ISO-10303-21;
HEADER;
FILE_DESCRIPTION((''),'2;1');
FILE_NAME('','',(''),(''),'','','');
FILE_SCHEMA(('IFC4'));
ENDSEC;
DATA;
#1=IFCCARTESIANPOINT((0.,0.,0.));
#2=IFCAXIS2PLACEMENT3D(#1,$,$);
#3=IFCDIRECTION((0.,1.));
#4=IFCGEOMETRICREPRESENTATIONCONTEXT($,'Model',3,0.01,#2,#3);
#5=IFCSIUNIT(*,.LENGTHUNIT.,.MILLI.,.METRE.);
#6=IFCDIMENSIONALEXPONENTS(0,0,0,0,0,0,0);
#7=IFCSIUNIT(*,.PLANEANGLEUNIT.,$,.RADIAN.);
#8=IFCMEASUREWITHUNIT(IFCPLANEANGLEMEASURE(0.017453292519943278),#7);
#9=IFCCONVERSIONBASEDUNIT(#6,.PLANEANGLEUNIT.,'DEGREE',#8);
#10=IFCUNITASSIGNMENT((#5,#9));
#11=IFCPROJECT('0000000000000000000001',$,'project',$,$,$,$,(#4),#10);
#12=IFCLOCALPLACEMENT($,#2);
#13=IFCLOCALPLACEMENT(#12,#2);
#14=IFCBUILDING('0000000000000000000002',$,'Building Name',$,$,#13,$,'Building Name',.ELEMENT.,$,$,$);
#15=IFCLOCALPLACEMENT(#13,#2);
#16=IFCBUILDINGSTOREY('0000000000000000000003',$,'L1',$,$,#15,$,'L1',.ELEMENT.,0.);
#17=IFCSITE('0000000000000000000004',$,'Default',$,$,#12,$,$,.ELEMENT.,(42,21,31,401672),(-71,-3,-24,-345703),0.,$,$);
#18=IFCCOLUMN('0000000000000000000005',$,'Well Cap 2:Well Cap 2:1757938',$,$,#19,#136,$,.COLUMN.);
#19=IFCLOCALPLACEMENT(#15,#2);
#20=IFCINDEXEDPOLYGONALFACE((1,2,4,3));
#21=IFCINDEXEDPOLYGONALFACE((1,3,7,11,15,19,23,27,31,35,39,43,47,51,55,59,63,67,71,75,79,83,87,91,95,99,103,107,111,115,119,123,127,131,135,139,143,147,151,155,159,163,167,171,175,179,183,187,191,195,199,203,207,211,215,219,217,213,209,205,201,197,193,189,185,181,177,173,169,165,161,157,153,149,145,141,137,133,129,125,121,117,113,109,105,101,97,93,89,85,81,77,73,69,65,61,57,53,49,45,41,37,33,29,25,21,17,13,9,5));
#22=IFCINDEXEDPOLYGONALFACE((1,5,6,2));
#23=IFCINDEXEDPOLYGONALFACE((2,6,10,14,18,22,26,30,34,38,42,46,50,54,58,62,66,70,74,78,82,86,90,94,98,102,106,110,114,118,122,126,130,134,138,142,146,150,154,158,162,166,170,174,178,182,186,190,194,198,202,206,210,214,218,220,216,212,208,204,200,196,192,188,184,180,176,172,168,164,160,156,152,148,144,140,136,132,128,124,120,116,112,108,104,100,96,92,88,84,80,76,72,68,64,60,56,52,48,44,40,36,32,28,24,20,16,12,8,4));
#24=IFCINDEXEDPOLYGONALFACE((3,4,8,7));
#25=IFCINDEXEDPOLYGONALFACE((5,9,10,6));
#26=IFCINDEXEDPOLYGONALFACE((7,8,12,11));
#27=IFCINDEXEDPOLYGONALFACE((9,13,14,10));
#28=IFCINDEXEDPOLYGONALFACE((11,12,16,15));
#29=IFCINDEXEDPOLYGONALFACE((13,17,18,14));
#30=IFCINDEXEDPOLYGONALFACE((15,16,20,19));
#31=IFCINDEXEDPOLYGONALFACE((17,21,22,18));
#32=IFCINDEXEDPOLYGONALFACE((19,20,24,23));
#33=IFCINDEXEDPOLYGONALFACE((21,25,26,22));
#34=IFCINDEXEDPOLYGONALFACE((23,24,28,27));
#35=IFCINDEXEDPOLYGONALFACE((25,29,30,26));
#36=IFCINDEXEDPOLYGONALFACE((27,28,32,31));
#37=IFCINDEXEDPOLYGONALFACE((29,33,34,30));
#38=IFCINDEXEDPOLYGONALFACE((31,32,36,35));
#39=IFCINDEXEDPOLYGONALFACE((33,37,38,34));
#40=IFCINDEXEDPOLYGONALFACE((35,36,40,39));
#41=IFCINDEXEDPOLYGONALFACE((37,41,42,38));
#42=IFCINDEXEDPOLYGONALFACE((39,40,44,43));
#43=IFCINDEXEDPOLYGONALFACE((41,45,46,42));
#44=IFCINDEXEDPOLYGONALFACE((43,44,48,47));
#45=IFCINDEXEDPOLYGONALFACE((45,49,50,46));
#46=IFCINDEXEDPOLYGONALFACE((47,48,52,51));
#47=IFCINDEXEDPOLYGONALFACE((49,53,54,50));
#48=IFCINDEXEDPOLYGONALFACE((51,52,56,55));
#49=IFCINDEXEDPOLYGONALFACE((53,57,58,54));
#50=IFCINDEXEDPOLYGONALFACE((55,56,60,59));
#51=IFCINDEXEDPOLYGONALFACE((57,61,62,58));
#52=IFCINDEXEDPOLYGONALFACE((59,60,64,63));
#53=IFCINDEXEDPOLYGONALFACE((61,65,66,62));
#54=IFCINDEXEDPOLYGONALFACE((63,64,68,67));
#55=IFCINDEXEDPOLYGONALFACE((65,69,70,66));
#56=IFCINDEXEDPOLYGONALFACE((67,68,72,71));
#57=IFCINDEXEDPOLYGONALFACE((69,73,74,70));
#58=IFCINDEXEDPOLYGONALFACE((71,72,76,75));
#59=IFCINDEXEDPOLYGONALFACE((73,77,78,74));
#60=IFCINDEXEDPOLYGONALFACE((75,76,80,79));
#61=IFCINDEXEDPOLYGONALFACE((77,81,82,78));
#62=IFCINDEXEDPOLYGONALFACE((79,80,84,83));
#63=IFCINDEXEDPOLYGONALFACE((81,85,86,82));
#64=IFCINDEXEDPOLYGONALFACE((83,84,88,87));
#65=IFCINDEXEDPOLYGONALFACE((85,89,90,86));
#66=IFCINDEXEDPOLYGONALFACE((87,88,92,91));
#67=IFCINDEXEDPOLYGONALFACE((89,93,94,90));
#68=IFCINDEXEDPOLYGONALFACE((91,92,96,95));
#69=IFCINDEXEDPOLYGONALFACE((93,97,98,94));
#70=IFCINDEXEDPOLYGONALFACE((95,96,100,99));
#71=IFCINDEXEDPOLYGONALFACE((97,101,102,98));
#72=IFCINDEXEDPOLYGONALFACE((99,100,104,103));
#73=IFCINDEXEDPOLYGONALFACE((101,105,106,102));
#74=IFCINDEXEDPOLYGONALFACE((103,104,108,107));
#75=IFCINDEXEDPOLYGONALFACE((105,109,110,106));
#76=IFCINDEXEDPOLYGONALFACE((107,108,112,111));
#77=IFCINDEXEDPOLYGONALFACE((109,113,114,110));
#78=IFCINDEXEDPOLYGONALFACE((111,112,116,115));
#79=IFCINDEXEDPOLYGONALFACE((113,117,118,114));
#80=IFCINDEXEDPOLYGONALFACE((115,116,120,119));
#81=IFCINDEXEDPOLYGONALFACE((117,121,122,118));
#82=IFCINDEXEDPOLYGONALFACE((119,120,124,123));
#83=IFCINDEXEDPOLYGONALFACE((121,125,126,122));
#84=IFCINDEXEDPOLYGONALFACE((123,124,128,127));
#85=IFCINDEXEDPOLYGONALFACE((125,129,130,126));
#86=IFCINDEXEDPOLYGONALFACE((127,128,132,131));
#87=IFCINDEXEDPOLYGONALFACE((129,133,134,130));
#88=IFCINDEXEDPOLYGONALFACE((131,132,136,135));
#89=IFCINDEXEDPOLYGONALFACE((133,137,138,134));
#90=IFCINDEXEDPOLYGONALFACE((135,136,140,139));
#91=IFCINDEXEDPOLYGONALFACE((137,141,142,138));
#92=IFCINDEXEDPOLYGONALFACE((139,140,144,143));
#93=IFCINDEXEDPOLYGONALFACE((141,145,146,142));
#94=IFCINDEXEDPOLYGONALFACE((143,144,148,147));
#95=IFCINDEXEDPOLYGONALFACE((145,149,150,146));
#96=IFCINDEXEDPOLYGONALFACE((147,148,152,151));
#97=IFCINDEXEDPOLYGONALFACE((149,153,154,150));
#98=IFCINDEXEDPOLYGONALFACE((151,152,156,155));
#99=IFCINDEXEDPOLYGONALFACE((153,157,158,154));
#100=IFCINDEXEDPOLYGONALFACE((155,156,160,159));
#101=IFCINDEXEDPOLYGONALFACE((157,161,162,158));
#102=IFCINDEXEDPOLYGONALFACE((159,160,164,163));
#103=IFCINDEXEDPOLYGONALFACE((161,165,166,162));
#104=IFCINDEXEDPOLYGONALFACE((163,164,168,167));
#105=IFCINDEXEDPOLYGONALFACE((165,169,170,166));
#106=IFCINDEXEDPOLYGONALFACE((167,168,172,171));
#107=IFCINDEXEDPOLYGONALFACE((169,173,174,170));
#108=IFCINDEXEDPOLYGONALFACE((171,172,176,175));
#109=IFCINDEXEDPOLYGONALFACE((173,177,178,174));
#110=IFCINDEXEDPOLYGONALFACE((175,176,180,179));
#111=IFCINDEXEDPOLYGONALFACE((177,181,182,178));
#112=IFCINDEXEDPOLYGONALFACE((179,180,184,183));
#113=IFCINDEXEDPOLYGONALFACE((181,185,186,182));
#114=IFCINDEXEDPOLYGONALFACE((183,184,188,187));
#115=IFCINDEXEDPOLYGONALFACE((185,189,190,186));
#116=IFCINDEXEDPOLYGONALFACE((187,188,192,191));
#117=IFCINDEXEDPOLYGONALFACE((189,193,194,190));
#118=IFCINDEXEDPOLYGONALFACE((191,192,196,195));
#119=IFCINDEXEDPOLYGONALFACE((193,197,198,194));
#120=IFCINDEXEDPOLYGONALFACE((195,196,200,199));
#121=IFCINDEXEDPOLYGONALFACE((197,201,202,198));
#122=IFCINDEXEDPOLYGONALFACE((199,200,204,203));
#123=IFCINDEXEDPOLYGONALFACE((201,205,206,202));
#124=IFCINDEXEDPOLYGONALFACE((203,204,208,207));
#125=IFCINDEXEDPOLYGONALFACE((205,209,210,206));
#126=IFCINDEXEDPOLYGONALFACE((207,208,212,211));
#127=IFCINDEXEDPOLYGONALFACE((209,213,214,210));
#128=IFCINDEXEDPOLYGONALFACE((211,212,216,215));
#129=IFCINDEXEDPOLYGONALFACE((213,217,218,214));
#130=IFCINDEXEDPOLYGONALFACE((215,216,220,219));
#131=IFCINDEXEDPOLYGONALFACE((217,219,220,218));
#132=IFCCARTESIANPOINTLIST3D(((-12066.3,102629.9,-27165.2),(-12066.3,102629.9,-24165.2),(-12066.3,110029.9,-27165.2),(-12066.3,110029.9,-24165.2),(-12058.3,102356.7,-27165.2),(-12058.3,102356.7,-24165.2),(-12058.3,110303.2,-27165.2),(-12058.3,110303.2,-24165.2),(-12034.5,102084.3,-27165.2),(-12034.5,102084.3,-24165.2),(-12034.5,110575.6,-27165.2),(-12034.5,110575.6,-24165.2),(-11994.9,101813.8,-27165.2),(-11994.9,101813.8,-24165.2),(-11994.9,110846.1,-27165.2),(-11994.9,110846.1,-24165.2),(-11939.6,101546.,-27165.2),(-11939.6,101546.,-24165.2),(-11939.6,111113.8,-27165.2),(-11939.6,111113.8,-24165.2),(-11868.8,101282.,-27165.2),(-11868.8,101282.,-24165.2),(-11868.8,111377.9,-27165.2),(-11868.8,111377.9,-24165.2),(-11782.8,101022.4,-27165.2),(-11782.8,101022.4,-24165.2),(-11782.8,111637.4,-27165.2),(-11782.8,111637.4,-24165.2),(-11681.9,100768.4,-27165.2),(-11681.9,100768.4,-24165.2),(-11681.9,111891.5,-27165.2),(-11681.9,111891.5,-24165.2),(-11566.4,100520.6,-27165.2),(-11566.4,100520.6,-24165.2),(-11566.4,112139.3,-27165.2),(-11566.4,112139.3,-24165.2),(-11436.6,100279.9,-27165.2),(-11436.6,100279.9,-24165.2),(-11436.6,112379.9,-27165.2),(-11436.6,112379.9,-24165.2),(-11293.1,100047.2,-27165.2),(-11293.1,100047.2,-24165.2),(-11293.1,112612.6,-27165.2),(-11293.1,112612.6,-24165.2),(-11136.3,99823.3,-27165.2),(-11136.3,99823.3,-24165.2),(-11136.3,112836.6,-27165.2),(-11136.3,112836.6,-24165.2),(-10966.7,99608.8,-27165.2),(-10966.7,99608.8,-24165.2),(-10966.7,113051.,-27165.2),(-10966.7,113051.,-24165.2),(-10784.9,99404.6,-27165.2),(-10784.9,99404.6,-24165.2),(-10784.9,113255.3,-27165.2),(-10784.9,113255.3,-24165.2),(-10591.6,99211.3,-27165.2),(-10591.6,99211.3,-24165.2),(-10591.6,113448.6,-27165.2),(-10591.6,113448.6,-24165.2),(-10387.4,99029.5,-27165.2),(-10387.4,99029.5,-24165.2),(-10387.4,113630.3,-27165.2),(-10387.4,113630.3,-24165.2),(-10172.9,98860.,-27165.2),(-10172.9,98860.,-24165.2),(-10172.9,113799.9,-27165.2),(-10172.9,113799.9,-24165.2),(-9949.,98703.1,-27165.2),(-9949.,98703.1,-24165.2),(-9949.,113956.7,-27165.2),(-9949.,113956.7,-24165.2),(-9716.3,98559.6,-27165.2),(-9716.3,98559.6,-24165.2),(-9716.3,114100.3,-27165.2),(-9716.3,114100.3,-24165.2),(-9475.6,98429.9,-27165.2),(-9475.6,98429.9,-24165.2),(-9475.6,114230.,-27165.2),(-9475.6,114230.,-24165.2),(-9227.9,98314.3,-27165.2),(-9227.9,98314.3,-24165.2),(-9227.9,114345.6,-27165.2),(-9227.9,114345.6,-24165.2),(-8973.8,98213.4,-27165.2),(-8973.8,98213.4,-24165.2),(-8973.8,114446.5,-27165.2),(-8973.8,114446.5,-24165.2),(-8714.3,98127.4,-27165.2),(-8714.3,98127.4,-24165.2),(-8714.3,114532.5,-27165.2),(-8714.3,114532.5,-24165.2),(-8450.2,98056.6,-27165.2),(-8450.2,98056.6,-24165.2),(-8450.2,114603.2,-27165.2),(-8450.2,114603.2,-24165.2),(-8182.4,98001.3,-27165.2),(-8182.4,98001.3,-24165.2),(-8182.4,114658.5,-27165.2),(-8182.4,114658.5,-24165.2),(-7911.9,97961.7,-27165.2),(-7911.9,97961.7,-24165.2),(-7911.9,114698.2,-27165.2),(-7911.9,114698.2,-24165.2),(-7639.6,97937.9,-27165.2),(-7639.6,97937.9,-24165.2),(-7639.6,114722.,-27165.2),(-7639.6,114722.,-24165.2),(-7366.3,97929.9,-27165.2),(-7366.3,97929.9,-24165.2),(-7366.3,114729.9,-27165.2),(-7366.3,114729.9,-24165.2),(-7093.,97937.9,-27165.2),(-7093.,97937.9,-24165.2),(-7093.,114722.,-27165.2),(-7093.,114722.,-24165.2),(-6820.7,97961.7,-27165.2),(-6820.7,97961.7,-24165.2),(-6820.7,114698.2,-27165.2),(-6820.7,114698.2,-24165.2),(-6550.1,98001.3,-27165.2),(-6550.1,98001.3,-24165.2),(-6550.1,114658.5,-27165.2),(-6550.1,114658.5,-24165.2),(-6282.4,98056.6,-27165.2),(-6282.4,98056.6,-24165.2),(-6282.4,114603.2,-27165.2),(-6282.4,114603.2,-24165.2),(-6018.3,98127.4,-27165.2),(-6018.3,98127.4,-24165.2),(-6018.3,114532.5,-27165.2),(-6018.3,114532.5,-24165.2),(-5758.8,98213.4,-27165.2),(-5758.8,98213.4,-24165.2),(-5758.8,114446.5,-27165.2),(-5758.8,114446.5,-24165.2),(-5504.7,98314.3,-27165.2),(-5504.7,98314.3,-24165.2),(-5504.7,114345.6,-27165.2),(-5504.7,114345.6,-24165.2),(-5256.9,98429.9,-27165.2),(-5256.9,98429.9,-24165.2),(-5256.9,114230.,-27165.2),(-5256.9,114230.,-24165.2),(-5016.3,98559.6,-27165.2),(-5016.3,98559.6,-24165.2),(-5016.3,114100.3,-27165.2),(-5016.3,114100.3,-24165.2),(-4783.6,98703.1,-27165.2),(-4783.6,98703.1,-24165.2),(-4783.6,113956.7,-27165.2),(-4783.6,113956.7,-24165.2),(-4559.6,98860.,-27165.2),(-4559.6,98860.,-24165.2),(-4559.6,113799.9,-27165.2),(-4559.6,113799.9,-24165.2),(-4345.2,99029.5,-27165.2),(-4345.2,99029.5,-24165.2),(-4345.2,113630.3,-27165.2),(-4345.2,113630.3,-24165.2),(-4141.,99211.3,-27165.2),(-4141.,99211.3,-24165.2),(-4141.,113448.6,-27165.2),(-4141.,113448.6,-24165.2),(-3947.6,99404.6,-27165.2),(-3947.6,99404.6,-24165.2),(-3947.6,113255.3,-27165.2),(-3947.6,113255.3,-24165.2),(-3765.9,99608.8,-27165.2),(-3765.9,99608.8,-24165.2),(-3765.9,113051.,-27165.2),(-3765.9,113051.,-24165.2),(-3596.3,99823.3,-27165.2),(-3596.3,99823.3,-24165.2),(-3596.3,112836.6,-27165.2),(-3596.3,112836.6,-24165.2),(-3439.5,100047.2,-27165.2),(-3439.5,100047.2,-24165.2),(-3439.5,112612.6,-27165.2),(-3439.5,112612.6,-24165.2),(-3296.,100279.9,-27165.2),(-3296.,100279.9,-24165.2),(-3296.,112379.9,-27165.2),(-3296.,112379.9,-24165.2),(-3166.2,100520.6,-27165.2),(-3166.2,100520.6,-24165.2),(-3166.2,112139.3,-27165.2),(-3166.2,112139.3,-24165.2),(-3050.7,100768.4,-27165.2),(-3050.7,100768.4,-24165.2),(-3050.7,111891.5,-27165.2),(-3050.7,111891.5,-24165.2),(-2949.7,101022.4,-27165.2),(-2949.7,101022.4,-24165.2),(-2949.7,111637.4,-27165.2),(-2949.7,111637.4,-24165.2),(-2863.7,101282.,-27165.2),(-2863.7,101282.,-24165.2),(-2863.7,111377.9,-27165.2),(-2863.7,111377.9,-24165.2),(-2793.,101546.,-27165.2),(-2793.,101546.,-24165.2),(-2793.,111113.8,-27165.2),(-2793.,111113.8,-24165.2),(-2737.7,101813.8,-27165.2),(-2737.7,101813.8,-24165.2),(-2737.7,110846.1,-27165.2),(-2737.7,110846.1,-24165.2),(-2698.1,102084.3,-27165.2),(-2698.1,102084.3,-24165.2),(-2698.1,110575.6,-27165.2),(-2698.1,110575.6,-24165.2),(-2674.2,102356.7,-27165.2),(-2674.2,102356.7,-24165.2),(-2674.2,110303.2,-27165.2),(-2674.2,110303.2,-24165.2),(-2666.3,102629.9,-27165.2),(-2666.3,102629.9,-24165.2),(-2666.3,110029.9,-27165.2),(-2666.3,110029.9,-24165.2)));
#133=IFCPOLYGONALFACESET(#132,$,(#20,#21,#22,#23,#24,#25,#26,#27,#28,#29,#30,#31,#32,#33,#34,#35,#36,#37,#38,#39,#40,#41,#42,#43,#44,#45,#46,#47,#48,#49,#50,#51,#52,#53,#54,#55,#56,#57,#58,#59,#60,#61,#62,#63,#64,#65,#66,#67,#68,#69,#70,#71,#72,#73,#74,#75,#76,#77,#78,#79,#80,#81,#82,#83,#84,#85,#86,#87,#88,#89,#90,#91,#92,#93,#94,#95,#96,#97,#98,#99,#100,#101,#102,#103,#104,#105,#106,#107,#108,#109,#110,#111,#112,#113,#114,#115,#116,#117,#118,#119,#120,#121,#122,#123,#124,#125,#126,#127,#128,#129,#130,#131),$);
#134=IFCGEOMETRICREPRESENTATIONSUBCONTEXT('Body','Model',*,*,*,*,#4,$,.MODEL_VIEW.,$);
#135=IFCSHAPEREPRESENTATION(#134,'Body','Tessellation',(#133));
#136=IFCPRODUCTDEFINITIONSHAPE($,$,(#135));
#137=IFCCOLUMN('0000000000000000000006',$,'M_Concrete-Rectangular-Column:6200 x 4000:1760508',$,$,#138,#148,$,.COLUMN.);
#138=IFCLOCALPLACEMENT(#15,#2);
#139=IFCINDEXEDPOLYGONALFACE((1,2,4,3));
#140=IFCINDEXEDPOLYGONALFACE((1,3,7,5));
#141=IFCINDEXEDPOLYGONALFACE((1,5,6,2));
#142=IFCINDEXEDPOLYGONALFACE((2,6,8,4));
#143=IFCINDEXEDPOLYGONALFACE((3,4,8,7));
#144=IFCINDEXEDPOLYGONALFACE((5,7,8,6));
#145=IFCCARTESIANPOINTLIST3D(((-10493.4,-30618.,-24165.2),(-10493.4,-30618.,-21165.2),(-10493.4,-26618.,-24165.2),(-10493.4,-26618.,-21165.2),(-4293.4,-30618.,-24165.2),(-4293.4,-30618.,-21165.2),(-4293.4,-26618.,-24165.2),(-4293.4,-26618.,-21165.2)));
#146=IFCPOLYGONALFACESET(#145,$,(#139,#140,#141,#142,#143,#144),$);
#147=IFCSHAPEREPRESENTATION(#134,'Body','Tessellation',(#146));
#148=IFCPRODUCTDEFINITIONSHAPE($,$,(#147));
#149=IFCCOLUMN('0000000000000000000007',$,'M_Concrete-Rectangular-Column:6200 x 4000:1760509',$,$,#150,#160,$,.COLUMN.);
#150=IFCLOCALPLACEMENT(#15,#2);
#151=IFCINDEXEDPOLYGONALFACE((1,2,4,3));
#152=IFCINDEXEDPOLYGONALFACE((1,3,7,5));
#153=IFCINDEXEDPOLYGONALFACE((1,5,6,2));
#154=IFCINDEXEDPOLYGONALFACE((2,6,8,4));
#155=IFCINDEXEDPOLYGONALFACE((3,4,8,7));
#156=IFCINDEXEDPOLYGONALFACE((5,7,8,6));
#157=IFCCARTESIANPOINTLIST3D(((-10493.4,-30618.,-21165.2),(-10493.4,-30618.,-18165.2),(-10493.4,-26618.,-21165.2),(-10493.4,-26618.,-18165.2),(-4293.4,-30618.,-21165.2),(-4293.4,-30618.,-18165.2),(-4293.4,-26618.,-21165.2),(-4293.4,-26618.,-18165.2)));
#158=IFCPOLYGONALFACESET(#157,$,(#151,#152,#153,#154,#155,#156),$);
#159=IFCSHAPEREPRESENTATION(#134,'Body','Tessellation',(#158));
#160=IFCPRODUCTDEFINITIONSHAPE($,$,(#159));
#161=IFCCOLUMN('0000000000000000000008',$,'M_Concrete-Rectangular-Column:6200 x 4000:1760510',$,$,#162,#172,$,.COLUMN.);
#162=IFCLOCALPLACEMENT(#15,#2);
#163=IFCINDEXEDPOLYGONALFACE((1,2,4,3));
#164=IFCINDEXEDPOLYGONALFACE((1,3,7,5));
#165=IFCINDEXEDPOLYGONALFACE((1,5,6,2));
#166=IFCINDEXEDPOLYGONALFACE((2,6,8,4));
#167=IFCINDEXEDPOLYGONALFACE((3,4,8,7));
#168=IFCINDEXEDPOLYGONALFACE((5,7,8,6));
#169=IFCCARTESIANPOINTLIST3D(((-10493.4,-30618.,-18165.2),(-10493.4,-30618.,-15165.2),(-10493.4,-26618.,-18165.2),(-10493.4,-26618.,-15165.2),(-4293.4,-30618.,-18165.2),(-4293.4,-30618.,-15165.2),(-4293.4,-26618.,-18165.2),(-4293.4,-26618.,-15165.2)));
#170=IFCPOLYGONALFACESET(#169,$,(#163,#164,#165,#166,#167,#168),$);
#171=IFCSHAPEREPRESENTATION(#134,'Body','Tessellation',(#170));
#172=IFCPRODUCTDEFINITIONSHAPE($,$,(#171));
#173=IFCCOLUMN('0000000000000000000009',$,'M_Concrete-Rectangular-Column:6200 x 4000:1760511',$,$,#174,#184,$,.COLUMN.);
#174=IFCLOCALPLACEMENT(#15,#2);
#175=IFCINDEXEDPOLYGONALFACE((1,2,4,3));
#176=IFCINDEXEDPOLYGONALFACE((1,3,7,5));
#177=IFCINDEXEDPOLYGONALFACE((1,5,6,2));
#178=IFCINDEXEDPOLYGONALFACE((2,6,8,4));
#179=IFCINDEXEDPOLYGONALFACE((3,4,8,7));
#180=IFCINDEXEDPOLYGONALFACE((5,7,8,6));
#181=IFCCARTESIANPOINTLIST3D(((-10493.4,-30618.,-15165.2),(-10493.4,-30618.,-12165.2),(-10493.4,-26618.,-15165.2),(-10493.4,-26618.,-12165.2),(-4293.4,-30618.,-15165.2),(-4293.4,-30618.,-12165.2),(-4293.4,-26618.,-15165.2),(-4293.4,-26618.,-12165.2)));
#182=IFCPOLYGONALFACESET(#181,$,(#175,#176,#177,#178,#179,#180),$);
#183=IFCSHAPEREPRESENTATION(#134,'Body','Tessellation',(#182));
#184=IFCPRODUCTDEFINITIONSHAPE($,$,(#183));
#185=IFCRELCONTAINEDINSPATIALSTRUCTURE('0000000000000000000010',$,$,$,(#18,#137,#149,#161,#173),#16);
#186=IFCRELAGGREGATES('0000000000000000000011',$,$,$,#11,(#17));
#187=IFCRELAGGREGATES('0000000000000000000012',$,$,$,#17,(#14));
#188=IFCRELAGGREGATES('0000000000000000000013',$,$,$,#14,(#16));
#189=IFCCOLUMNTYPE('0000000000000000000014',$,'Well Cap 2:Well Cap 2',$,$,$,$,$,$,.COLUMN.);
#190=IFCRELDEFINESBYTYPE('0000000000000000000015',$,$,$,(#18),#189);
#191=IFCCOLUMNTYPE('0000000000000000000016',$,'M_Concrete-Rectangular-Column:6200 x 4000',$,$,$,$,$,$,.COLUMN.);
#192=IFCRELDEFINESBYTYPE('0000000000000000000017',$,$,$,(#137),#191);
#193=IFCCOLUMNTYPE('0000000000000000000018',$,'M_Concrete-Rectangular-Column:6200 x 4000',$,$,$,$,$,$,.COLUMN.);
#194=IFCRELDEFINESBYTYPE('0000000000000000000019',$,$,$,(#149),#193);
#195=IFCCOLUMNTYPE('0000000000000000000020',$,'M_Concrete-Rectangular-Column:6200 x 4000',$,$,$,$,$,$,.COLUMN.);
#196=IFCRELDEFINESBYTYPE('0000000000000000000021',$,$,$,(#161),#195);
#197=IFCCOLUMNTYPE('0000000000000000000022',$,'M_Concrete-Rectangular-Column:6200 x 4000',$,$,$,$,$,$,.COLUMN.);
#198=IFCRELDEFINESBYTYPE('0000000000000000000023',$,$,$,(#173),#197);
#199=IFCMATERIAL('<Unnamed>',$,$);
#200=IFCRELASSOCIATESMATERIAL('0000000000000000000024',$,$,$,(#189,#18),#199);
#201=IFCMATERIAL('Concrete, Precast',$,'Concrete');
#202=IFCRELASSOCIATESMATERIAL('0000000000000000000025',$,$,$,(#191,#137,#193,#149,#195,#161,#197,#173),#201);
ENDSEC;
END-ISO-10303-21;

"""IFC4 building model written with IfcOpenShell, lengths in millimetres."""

from ifc_helpers import new_model, entity, si_unit, converted_unit, direction, frame, origin, place, context, subcontext, project, spatial, line, arc, indexed_curve, outline, extrude, source, transform, mapped, material, type_object, type_shapes, element, save


model = new_model("IFC4")

# Units and contexts
model_context = context("Model", 3, precision=0.01, world=origin(), true_north=direction((0.0, 1.0)))
body_context = subcontext(model_context, "Body", "Model", "MODEL_VIEW")
ifc_project = project(units=[si_unit("LENGTHUNIT", "METRE", prefix="MILLI"), converted_unit("PLANEANGLEUNIT", "DEGREE", entity("IfcPlaneAngleMeasure", 0.017453292519943278), si_unit("PLANEANGLEUNIT", "RADIAN"), dimensions=[0, 0, 0, 0, 0, 0, 0])], contexts=[model_context])

# Site, building, storey
site_placement = place(None, origin())
site = spatial("IfcSite", under=ifc_project, at=site_placement, Name="Default", CompositionType="ELEMENT", RefLatitude=(42, 21, 31, 401672), RefLongitude=(-71, -3, -24, -345703), RefElevation=0.0)
building_placement = place(site_placement, origin())
building = spatial("IfcBuilding", under=site, at=building_placement, Name="Building Name", LongName="Building Name", CompositionType="ELEMENT")
storey_placement = place(building_placement, origin())
storey = spatial("IfcBuildingStorey", under=building, at=storey_placement, Name="L1", LongName="L1", CompositionType="ELEMENT", Elevation=0.0)

# Columns
ifc_material_1 = material(Name="<Unnamed>")
column_type_1 = type_object("IfcColumnType", Name="Well Cap 2:Well Cap 2", PredefinedType="COLUMN", material=ifc_material_1)
shared_shape_1 = source(origin(), body_context, "Body", "SweptSolid", [
    extrude(outline(indexed_curve([(-3700.0, -4700.0), (3700.0, -4700.0), (8400.0, 0.0), (3700.0, 4700.0), (-3700.0, 4700.0), (-8400.0, 0.0)], segments=[line(1, 2), arc(2, 3, 4), line(4, 5), arc(5, 6, 1)], self_intersect=False)), frame((8064.3, 0.0, 0.0), z_axis=(0.0, 0.0, 1.0), x_axis=(0.0, -1.0, 0.0)), (0.0, 0.0, 1.0), 3000.0),
])
type_shapes(column_type_1, [shared_shape_1])
column_1_placement = place(storey_placement, frame((-15430.5, 106329.9, -27165.2)))
element("IfcColumn", 1, at=column_1_placement, inside=storey, type_object=column_type_1, material=ifc_material_1, Name="Well Cap 2:Well Cap 2:1757938", PredefinedType="COLUMN", context=body_context, shape_type="MappedRepresentation", body=[
    mapped(shared_shape_1, transform((0.0, 0.0, 0.0), scale=1.0)),
])
ifc_material_2 = material(Name="Concrete, Precast", Category="Concrete")
column_type_2 = type_object("IfcColumnType", Name="M_Concrete-Rectangular-Column:6200 x 4000", PredefinedType="COLUMN", material=ifc_material_2)
shared_shape_2 = source(origin(), body_context, "Body", "SweptSolid", [
    extrude(outline(indexed_curve([(-2000.0, -3100.0), (2000.0, -3100.0), (2000.0, 3100.0), (-2000.0, 3100.0), (-2000.0, -3100.0)], self_intersect=False)), frame((-7393.4, -28618.0, -24165.2), z_axis=(0.0, 0.0, 1.0), x_axis=(0.0, -1.0, 0.0)), (0.0, 0.0, 1.0), 3000.0),
])
type_shapes(column_type_2, [shared_shape_2])
column_2_placement = place(storey_placement, origin())
element("IfcColumn", 2, at=column_2_placement, inside=storey, type_object=column_type_2, material=ifc_material_2, Name="M_Concrete-Rectangular-Column:6200 x 4000:1760508", PredefinedType="COLUMN", context=body_context, shape_type="MappedRepresentation", body=[
    mapped(shared_shape_2, transform((0.0, 0.0, 0.0), scale=1.0)),
])
column_type_3 = type_object("IfcColumnType", Name="M_Concrete-Rectangular-Column:6200 x 4000", PredefinedType="COLUMN", material=ifc_material_2)
shared_shape_3 = source(origin(), body_context, "Body", "SweptSolid", [
    extrude(outline(indexed_curve([(-2000.0, -3100.0), (2000.0, -3100.0), (2000.0, 3100.0), (-2000.0, 3100.0), (-2000.0, -3100.0)], self_intersect=False)), frame((-7393.4, -28618.0, -21165.2), z_axis=(0.0, 0.0, 1.0), x_axis=(0.0, -1.0, 0.0)), (0.0, 0.0, 1.0), 3000.0),
])
type_shapes(column_type_3, [shared_shape_3])
column_3_placement = place(storey_placement, origin())
element("IfcColumn", 3, at=column_3_placement, inside=storey, type_object=column_type_3, material=ifc_material_2, Name="M_Concrete-Rectangular-Column:6200 x 4000:1760509", PredefinedType="COLUMN", context=body_context, shape_type="MappedRepresentation", body=[
    mapped(shared_shape_3, transform((0.0, 0.0, 0.0), scale=1.0)),
])
column_type_4 = type_object("IfcColumnType", Name="M_Concrete-Rectangular-Column:6200 x 4000", PredefinedType="COLUMN", material=ifc_material_2)
shared_shape_4 = source(origin(), body_context, "Body", "SweptSolid", [
    extrude(outline(indexed_curve([(-2000.0, -3100.0), (2000.0, -3100.0), (2000.0, 3100.0), (-2000.0, 3100.0), (-2000.0, -3100.0)], self_intersect=False)), frame((-7393.4, -28618.0, -18165.2), z_axis=(0.0, 0.0, 1.0), x_axis=(0.0, -1.0, 0.0)), (0.0, 0.0, 1.0), 3000.0),
])
type_shapes(column_type_4, [shared_shape_4])
column_4_placement = place(storey_placement, origin())
element("IfcColumn", 4, at=column_4_placement, inside=storey, type_object=column_type_4, material=ifc_material_2, Name="M_Concrete-Rectangular-Column:6200 x 4000:1760510", PredefinedType="COLUMN", context=body_context, shape_type="MappedRepresentation", body=[
    mapped(shared_shape_4, transform((0.0, 0.0, 0.0), scale=1.0)),
])
column_type_5 = type_object("IfcColumnType", Name="M_Concrete-Rectangular-Column:6200 x 4000", PredefinedType="COLUMN", material=ifc_material_2)
shared_shape_5 = source(origin(), body_context, "Body", "SweptSolid", [
    extrude(outline(indexed_curve([(-2000.0, -3100.0), (2000.0, -3100.0), (2000.0, 3100.0), (-2000.0, 3100.0), (-2000.0, -3100.0)], self_intersect=False)), frame((-7393.4, -28618.0, -15165.2), z_axis=(0.0, 0.0, 1.0), x_axis=(0.0, -1.0, 0.0)), (0.0, 0.0, 1.0), 3000.0),
])
type_shapes(column_type_5, [shared_shape_5])
column_5_placement = place(storey_placement, origin())
element("IfcColumn", 5, at=column_5_placement, inside=storey, type_object=column_type_5, material=ifc_material_2, Name="M_Concrete-Rectangular-Column:6200 x 4000:1760511", PredefinedType="COLUMN", context=body_context, shape_type="MappedRepresentation", body=[
    mapped(shared_shape_5, transform((0.0, 0.0, 0.0), scale=1.0)),
])

save(model, "model.ifc")
